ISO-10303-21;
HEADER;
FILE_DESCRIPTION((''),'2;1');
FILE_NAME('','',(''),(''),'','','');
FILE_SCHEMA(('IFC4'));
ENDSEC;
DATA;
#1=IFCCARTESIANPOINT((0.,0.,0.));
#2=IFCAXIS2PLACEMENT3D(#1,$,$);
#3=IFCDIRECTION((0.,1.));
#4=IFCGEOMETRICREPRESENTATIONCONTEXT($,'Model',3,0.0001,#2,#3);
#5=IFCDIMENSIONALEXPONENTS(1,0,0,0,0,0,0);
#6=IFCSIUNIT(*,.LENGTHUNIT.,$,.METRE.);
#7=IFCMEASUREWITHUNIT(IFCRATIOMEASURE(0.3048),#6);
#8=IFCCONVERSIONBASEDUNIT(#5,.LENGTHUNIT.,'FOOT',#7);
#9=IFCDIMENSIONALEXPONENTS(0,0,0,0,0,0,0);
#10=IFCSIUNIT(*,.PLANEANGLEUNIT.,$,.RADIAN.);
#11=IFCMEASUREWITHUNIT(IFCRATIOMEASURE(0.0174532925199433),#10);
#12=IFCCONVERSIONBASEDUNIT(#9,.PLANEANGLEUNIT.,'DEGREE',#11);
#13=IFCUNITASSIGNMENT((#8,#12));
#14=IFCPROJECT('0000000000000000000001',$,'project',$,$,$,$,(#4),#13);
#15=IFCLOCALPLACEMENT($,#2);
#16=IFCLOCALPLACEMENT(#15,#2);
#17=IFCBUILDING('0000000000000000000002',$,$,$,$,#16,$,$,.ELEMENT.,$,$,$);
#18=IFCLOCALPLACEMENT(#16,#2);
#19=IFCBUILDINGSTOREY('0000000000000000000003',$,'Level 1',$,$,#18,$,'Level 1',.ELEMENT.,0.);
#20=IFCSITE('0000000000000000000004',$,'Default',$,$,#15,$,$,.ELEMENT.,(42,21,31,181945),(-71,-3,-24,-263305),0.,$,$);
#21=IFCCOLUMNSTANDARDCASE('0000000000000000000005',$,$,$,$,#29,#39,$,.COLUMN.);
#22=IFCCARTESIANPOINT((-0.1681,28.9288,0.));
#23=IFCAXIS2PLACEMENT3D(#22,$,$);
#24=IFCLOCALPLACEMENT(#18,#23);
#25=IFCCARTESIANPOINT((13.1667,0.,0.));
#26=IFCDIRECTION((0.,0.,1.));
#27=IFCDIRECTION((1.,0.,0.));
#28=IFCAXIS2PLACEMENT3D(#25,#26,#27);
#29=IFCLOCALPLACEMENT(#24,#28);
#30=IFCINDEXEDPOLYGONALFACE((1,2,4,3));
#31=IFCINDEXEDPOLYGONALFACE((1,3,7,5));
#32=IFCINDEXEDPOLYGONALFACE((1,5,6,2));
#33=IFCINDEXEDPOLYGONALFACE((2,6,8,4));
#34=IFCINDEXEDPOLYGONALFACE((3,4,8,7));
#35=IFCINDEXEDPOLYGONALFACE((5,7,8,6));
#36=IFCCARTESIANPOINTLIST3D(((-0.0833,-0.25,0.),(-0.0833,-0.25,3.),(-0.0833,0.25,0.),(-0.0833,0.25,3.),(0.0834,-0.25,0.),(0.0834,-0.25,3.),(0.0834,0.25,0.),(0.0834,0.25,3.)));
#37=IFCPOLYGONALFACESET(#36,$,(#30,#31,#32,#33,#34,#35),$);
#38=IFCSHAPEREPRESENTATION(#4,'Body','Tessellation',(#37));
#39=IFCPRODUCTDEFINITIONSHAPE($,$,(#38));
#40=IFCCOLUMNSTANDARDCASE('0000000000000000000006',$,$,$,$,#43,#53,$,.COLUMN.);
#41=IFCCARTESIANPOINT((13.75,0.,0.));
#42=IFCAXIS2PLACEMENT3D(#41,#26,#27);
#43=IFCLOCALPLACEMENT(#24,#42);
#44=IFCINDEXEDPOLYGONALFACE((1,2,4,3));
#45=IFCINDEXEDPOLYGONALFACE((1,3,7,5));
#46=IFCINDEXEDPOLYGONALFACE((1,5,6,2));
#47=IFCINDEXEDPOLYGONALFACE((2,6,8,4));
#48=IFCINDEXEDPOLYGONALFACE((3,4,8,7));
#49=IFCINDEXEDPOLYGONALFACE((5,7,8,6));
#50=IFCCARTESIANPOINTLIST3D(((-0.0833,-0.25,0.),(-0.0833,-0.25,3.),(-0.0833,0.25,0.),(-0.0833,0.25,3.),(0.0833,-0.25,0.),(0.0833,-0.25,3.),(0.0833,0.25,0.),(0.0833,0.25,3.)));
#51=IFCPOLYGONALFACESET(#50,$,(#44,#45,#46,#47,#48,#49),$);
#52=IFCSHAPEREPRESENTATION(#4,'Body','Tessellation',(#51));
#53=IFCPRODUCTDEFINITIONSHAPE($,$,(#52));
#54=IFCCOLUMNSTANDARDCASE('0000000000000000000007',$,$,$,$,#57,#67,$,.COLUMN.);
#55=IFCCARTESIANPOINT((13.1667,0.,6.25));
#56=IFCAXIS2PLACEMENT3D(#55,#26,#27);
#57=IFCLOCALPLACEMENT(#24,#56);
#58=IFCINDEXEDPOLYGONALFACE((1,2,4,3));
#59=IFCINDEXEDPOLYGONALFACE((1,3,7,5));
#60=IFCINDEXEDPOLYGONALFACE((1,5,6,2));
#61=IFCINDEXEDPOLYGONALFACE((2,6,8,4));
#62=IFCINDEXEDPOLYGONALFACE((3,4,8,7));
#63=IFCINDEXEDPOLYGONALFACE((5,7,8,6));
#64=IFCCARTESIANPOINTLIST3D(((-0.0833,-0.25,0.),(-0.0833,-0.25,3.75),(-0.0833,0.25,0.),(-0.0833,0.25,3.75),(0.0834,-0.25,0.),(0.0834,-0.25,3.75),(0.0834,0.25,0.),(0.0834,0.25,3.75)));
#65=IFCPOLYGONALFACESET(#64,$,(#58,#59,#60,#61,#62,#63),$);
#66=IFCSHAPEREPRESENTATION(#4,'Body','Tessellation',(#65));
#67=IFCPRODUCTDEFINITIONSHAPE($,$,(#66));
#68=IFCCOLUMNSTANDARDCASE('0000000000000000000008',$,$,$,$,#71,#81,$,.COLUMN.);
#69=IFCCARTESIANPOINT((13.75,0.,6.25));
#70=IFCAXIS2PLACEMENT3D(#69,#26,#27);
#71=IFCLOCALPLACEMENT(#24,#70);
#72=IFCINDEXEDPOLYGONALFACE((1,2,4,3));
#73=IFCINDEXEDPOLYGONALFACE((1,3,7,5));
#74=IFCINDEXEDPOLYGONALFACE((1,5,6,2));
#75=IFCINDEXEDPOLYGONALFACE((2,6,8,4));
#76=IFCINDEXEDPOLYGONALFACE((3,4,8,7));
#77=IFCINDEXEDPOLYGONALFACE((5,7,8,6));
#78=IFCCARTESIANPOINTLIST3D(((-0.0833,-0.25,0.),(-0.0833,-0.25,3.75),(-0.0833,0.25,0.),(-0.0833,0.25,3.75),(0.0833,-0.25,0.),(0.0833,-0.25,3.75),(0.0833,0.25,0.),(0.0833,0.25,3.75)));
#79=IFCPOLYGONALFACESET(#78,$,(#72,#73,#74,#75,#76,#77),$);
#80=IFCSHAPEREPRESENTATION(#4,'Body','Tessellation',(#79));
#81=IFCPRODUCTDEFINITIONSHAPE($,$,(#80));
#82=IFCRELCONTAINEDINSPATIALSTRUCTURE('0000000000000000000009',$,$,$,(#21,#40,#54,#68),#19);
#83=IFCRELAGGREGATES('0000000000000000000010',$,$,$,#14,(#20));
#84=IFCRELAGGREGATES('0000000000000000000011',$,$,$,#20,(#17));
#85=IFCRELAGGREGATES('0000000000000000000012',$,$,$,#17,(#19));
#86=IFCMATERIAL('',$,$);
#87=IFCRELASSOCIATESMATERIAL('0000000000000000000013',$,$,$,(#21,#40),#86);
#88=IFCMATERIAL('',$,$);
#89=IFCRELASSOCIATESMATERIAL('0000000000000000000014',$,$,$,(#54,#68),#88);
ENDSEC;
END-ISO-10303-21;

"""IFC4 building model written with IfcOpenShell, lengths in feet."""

from ifc_helpers import new_model, entity, si_unit, converted_unit, direction, frame, origin, place, context, project, spatial, rectangle, extrude, material, element, save


model = new_model("IFC4")

# Units and contexts
model_context = context("Model", 3, precision=0.0001, world=origin(), true_north=direction((0.0, 1.0)))
ifc_project = project(units=[converted_unit("LENGTHUNIT", "FOOT", entity("IfcRatioMeasure", 0.3048), si_unit("LENGTHUNIT", "METRE"), dimensions=[1, 0, 0, 0, 0, 0, 0]), converted_unit("PLANEANGLEUNIT", "DEGREE", entity("IfcRatioMeasure", 0.0174532925199433), si_unit("PLANEANGLEUNIT", "RADIAN"), dimensions=[0, 0, 0, 0, 0, 0, 0])], contexts=[model_context])

# Site, building, storey
site_placement = place(None, origin())
site = spatial("IfcSite", under=ifc_project, at=site_placement, Name="Default", CompositionType="ELEMENT", RefLatitude=(42, 21, 31, 181945), RefLongitude=(-71, -3, -24, -263305), RefElevation=0.0)
building_placement = place(site_placement, origin())
building = spatial("IfcBuilding", under=site, at=building_placement, CompositionType="ELEMENT")
storey_placement = place(building_placement, origin())
storey = spatial("IfcBuildingStorey", under=building, at=storey_placement, Name="Level 1", LongName="Level 1", CompositionType="ELEMENT", Elevation=0.0)

# Columns
ifc_material_1 = material(Name="")
placement = place(storey_placement, frame((-0.1681, 28.9288, 0.0)))
for number, where, z_axis, x_axis in (
    (1, (13.1667, 0.0, 0.0), (0.0, 0.0, 1.0), (1.0, 0.0, 0.0)),
    (2, (13.75, 0.0, 0.0), (0.0, 0.0, 1.0), (1.0, 0.0, 0.0)),
):
    element("IfcColumnStandardCase", number, at=place(placement, frame(where, z_axis=z_axis, x_axis=x_axis)), inside=storey, material=ifc_material_1, PredefinedType="COLUMN", context=model_context, shape_type="SweptSolid", body=[
        extrude(rectangle(XDim=0.1667, YDim=0.5), origin(), (0.0, 0.0, 1.0), 3.0),
    ])
ifc_material_2 = material(Name="")
for number, where, z_axis, x_axis in (
    (3, (13.1667, 0.0, 6.25), (0.0, 0.0, 1.0), (1.0, 0.0, 0.0)),
    (4, (13.75, 0.0, 6.25), (0.0, 0.0, 1.0), (1.0, 0.0, 0.0)),
):
    element("IfcColumnStandardCase", number, at=place(placement, frame(where, z_axis=z_axis, x_axis=x_axis)), inside=storey, material=ifc_material_2, PredefinedType="COLUMN", context=model_context, shape_type="SweptSolid", body=[
        extrude(rectangle(XDim=0.1667, YDim=0.5), origin(), (0.0, 0.0, 1.0), 3.75),
    ])

save(model, "model.ifc")
